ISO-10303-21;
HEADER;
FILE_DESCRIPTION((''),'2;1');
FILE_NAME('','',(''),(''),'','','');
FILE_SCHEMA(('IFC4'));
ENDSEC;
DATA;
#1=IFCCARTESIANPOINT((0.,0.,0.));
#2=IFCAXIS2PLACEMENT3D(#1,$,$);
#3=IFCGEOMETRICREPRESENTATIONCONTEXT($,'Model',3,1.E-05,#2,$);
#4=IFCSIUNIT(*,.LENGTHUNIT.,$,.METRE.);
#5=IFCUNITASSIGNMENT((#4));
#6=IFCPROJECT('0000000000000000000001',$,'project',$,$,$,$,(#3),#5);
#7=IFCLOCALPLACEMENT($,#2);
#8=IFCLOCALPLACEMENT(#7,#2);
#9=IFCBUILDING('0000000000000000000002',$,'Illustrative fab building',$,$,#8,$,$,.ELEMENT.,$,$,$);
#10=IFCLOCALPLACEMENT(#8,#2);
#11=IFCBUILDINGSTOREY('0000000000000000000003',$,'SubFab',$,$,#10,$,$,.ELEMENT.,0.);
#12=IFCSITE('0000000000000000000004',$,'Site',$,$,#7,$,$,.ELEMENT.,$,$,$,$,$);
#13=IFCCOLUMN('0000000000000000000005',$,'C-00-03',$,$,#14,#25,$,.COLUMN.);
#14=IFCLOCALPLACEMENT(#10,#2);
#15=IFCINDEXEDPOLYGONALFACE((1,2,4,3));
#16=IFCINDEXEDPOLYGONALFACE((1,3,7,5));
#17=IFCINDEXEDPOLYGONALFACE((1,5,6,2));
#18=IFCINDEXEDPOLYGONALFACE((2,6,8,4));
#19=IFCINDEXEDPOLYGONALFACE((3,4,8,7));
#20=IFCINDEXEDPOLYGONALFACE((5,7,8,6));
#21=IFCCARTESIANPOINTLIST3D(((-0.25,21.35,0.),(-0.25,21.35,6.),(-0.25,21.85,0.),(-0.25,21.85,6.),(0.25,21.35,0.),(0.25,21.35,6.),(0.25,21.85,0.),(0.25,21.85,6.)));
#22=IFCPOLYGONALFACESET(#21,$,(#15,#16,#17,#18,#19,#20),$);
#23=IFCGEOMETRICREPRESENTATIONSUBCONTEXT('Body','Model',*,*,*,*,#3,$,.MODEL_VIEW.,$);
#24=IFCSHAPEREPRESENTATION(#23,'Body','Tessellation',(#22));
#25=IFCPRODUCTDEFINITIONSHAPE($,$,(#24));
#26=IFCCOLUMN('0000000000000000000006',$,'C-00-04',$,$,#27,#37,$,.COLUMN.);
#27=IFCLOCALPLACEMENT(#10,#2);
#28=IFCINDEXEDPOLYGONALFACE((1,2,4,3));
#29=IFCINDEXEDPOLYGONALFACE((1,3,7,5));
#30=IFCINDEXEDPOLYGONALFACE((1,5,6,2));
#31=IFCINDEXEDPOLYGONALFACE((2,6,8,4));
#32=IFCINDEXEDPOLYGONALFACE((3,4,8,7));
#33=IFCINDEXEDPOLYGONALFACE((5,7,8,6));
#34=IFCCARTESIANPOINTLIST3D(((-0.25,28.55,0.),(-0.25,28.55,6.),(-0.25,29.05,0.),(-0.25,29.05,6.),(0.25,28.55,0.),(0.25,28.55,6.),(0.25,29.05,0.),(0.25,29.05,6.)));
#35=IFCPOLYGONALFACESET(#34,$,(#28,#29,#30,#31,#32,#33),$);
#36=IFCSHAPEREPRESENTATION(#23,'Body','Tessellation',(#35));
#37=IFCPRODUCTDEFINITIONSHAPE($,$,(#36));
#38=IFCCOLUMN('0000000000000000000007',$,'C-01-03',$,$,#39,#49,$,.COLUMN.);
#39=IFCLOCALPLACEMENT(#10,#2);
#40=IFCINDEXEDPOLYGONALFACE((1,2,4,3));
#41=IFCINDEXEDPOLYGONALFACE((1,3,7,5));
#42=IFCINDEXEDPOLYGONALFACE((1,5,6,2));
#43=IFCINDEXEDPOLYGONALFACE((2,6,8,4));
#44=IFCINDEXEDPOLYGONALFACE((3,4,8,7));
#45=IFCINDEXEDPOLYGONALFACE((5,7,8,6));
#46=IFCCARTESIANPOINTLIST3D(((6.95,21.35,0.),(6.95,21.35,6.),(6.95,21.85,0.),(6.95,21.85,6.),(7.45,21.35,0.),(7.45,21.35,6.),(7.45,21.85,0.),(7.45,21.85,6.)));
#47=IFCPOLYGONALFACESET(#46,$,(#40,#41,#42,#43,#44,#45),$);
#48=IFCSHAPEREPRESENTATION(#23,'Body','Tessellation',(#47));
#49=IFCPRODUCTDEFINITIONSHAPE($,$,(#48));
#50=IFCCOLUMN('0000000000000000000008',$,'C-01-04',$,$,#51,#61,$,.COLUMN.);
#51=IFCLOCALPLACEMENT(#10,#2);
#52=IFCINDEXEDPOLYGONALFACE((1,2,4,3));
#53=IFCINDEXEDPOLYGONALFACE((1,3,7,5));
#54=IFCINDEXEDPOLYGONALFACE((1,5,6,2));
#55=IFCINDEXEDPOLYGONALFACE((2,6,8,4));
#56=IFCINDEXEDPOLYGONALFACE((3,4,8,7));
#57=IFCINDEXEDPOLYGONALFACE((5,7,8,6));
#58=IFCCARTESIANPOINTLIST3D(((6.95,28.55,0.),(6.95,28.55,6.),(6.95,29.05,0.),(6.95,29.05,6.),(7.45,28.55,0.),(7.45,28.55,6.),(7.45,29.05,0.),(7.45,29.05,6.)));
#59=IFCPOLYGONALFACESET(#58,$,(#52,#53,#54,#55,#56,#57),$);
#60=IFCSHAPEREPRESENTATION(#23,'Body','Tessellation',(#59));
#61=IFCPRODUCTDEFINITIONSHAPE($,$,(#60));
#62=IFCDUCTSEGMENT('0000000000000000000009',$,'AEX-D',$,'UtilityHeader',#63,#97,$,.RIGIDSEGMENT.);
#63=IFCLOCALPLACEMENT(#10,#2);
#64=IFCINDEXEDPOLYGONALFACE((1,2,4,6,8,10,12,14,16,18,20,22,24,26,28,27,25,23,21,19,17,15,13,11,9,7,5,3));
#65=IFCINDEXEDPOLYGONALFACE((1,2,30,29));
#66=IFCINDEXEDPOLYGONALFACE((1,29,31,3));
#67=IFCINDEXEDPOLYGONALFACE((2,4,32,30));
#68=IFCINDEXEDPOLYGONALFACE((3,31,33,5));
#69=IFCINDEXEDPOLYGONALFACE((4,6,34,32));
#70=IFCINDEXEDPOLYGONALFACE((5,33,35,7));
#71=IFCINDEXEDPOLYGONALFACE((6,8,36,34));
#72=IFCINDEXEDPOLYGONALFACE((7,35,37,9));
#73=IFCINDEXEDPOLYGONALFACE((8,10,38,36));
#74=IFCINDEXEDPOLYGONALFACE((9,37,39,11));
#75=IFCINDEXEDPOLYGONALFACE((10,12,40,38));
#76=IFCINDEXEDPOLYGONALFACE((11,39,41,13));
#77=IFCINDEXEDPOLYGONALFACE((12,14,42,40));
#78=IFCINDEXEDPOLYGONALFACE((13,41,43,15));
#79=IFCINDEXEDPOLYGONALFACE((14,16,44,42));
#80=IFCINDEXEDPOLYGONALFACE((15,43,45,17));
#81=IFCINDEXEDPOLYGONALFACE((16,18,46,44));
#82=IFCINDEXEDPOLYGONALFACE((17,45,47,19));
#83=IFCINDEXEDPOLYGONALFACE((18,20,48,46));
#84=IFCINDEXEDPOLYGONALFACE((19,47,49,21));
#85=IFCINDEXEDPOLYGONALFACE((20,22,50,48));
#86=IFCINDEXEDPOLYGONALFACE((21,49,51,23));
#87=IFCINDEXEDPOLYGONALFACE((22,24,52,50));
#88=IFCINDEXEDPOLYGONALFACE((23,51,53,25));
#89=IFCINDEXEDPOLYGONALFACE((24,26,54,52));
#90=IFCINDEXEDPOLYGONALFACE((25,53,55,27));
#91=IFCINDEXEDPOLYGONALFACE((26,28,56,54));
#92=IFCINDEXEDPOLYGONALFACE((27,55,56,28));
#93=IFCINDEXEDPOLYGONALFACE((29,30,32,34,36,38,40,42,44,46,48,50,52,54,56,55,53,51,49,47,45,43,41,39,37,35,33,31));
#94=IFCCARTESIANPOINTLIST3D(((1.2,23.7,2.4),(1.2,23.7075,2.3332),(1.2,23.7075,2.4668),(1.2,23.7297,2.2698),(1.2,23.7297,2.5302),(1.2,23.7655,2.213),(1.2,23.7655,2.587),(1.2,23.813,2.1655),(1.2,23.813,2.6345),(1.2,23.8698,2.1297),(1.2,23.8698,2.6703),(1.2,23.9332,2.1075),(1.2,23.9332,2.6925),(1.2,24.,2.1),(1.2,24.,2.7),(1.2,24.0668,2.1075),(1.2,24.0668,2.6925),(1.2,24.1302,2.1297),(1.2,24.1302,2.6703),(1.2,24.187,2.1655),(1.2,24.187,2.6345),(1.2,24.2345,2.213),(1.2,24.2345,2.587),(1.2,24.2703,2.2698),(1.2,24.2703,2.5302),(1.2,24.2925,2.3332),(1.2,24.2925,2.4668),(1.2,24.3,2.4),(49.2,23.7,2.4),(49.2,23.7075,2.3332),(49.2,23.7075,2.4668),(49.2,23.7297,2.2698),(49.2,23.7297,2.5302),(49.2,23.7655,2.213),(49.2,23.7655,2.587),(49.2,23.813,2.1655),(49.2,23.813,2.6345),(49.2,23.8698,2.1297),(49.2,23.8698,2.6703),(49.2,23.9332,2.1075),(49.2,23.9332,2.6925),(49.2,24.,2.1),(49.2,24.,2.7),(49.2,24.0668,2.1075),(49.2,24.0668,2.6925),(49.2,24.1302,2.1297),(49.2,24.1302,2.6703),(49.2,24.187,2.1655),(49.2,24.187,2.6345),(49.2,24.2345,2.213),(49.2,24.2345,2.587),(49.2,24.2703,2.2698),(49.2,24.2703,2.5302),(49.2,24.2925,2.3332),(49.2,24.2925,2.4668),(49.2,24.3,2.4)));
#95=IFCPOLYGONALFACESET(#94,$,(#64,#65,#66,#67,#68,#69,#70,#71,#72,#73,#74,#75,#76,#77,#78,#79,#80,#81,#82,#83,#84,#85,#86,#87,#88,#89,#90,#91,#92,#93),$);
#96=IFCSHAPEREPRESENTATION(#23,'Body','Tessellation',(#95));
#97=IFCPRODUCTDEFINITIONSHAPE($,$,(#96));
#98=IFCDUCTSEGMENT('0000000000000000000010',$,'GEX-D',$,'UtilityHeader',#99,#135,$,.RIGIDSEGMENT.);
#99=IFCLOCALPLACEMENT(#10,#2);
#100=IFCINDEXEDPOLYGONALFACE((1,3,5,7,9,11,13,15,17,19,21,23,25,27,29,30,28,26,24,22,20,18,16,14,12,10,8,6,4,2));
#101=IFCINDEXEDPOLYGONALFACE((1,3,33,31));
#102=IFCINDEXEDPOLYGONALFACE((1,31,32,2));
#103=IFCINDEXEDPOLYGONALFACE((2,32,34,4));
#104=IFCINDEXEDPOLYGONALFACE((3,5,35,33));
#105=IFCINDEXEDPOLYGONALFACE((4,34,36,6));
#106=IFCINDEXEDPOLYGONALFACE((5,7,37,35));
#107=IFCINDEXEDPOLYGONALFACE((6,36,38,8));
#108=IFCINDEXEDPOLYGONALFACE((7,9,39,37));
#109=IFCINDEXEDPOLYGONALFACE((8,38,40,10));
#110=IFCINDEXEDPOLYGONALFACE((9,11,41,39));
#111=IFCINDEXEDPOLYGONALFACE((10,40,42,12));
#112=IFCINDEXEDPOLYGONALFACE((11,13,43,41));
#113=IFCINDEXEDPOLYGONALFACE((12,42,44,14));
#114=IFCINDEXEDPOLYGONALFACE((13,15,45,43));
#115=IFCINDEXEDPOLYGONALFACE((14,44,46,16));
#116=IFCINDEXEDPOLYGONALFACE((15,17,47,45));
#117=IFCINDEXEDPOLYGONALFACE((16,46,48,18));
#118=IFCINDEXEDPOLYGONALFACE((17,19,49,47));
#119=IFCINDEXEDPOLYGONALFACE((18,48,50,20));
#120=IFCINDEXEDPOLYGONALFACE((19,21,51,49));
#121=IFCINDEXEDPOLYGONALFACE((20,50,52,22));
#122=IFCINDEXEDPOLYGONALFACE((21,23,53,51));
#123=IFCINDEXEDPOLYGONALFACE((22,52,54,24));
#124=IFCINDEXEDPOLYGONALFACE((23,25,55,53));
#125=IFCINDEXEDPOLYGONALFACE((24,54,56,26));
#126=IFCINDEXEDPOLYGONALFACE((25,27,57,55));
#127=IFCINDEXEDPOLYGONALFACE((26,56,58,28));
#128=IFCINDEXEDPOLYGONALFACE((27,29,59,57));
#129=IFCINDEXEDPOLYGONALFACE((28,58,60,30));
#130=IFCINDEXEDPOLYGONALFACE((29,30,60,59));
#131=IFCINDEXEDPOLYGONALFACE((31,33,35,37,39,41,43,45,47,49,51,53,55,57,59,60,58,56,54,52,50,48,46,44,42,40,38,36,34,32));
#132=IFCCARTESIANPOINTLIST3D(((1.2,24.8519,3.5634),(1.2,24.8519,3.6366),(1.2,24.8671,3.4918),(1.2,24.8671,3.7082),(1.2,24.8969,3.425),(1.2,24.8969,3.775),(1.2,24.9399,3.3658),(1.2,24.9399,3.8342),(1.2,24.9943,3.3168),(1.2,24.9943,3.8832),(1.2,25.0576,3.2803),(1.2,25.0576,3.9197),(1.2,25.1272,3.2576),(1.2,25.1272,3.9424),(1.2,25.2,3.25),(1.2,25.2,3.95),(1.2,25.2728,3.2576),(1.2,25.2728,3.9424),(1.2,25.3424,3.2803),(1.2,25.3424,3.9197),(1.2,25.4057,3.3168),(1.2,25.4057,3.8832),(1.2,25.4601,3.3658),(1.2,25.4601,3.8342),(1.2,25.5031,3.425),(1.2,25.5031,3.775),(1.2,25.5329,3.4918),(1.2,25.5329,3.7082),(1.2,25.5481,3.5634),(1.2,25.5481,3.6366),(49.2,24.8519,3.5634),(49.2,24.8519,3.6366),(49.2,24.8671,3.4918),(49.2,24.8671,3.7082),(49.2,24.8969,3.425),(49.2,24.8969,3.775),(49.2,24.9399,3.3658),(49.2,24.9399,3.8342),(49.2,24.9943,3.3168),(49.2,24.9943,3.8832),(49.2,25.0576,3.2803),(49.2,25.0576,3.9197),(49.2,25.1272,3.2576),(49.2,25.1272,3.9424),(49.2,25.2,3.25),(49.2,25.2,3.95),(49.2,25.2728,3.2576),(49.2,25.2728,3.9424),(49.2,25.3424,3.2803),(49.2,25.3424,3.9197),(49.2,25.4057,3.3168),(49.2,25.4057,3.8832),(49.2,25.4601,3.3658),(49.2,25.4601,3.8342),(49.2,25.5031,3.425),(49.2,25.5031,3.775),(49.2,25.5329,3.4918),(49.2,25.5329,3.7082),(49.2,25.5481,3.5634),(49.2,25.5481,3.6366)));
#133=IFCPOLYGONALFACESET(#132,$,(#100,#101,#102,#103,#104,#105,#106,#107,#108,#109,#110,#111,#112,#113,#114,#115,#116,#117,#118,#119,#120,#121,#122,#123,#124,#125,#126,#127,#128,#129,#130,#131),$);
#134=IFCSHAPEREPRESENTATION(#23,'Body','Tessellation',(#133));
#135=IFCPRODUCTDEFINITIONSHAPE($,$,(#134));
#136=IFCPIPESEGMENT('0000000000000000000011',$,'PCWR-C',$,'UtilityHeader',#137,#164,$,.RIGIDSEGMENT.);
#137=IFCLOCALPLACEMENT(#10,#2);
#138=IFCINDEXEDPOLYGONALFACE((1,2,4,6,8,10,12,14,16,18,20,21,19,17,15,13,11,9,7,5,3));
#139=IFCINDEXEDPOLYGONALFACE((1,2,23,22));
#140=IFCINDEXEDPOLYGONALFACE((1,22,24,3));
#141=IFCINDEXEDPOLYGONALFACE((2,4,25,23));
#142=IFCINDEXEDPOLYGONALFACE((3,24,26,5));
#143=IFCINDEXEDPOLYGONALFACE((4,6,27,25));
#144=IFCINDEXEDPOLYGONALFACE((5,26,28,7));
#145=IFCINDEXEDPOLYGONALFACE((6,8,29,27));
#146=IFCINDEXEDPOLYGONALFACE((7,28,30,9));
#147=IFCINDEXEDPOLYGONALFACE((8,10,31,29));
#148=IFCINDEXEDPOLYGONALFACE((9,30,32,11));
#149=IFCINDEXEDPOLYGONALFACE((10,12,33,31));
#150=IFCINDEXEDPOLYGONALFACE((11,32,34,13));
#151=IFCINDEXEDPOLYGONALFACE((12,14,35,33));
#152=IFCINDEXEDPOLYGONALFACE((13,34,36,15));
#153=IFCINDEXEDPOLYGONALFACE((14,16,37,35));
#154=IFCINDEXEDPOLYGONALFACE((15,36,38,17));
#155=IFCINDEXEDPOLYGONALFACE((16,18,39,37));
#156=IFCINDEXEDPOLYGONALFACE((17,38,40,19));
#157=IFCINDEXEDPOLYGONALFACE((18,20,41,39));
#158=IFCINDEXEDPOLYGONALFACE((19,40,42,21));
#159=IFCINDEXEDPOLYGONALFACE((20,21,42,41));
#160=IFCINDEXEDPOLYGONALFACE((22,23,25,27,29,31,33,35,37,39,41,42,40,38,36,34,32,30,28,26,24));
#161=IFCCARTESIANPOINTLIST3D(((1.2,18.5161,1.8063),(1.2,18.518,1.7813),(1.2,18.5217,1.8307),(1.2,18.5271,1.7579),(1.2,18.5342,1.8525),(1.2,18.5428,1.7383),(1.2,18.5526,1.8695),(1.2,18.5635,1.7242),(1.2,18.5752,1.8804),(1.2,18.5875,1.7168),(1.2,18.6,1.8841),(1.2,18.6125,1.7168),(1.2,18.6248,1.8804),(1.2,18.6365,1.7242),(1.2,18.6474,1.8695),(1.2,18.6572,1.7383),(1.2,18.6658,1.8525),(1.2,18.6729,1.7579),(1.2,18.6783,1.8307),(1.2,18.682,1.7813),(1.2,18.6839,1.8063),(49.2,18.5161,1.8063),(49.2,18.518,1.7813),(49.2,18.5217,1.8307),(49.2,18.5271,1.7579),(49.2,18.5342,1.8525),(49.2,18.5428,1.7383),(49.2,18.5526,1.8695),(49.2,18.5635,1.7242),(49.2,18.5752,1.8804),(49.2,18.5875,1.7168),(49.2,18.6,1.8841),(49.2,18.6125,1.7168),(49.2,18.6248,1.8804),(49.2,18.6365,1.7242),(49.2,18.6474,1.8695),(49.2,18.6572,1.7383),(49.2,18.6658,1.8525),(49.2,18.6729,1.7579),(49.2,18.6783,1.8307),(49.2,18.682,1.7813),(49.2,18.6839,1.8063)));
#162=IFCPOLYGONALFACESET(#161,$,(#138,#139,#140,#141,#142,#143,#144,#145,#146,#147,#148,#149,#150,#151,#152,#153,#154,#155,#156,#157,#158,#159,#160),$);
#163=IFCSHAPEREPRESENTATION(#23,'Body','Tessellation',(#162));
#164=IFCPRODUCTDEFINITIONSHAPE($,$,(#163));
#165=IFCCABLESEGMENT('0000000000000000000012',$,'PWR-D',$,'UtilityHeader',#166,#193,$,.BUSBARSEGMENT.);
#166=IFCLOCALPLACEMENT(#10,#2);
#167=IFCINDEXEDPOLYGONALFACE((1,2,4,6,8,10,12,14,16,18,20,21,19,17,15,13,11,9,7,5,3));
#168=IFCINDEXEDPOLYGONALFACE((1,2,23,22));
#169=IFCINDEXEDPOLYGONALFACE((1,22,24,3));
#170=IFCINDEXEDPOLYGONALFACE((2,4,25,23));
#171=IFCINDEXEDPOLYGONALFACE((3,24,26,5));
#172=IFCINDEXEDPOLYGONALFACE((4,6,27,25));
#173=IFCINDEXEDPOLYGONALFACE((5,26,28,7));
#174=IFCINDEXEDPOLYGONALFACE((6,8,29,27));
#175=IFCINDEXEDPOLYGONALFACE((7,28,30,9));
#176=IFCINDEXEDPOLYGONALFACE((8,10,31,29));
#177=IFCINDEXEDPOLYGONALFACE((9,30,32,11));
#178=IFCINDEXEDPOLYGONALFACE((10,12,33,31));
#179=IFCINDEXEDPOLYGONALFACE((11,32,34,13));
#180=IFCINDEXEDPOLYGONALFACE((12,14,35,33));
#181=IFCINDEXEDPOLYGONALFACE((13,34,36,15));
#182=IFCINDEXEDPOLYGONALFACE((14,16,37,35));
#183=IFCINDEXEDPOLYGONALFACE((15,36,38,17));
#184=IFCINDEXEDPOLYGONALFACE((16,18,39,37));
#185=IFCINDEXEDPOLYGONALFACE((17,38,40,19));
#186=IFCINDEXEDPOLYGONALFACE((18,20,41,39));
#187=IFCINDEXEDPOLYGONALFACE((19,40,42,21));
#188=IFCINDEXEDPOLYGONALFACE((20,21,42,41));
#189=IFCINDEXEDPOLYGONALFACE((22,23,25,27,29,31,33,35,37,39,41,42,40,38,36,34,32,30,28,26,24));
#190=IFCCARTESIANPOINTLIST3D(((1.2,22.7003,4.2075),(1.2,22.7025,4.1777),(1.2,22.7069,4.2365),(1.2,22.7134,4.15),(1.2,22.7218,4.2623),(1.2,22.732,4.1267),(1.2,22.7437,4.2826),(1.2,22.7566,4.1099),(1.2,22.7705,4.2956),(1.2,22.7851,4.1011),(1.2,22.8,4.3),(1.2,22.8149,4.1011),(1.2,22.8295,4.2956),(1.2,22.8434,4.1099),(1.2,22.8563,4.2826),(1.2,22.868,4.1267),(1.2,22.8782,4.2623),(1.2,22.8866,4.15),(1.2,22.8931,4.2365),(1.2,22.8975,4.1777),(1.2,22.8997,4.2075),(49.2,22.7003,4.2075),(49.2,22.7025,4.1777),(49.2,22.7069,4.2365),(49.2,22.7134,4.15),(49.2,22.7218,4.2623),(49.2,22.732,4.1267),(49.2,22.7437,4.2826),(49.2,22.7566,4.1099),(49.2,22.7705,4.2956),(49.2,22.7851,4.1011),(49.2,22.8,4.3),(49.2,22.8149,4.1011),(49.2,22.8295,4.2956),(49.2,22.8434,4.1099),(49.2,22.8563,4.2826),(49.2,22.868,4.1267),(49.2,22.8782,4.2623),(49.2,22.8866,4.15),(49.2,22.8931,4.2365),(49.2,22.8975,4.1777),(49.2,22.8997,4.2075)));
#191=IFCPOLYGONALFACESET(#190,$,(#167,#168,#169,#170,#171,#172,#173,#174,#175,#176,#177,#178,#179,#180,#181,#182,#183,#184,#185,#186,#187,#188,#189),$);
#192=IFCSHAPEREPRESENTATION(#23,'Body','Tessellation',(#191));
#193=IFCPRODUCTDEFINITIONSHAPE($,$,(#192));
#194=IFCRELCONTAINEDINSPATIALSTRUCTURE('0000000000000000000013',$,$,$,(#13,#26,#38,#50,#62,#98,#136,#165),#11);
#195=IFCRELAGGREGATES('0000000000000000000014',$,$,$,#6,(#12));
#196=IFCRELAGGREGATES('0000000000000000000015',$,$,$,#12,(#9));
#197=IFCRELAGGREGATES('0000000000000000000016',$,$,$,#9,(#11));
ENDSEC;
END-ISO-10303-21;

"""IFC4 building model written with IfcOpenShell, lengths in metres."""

from ifc_helpers import new_model, entity, si_unit, frame, origin, origin_2d, place, context, subcontext, project, spatial, rectangle, extrude, element, save


model = new_model("IFC4")

# Units and contexts
model_context = context("Model", 3, precision=1e-05, world=origin())
body_context = subcontext(model_context, "Body", "Model", "MODEL_VIEW")
ifc_project = project(units=[si_unit("LENGTHUNIT", "METRE")], contexts=[model_context])

# Site, building, storey
site_placement = place(None, origin())
site = spatial("IfcSite", under=ifc_project, at=site_placement, Name="Site", CompositionType="ELEMENT")
building_placement = place(site_placement, origin())
building = spatial("IfcBuilding", under=site, at=building_placement, Name="Illustrative fab building", CompositionType="ELEMENT")
storey_placement = place(building_placement, origin())
storey = spatial("IfcBuildingStorey", under=building, at=storey_placement, Name="SubFab", CompositionType="ELEMENT", Elevation=0.0)

# Columns
for number, where, name in (
    (1, (0.0, 21.6, 0.0), "C-00-03"),
    (2, (0.0, 28.8, 0.0), "C-00-04"),
    (3, (7.2, 21.6, 0.0), "C-01-03"),
    (4, (7.2, 28.8, 0.0), "C-01-04"),
):
    element("IfcColumn", number, at=place(storey_placement, frame(where)), inside=storey, Name=name, PredefinedType="COLUMN", context=body_context, shape_type="SweptSolid", body=[
        extrude(rectangle(XDim=0.5, YDim=0.5, at=origin_2d()), origin(), (0.0, 0.0, 1.0), 6.0),
    ])

# Duct segments
duct_segment_1_placement = place(storey_placement, frame((1.2, 24.0, 2.4)))
element("IfcDuctSegment", 5, at=duct_segment_1_placement, inside=storey, Name="AEX-D", ObjectType="UtilityHeader", PredefinedType="RIGIDSEGMENT", context=body_context, shape_type="AdvancedSweptSolid", body=[
    entity("IfcSweptDiskSolid", entity("IfcPolyline", [entity("IfcCartesianPoint", [0.0, 0.0, 0.0]), entity("IfcCartesianPoint", [48.0, 0.0, 0.0])]), 0.3),
])
duct_segment_2_placement = place(storey_placement, frame((1.2, 25.2, 3.6)))
element("IfcDuctSegment", 6, at=duct_segment_2_placement, inside=storey, Name="GEX-D", ObjectType="UtilityHeader", PredefinedType="RIGIDSEGMENT", context=body_context, shape_type="AdvancedSweptSolid", body=[
    entity("IfcSweptDiskSolid", entity("IfcPolyline", [entity("IfcCartesianPoint", [0.0, 0.0, 0.0]), entity("IfcCartesianPoint", [48.0, 0.0, 0.0])]), 0.35),
])

# Pipe segment
pipe_segment_placement = place(storey_placement, frame((1.2, 18.6, 1.8)))
element("IfcPipeSegment", 7, at=pipe_segment_placement, inside=storey, Name="PCWR-C", ObjectType="UtilityHeader", PredefinedType="RIGIDSEGMENT", context=body_context, shape_type="AdvancedSweptSolid", body=[
    entity("IfcSweptDiskSolid", entity("IfcPolyline", [entity("IfcCartesianPoint", [0.0, 0.0, 0.0]), entity("IfcCartesianPoint", [48.0, 0.0, 0.0])]), 0.0841),
])

# Cable segment
cable_segment_placement = place(storey_placement, frame((1.2, 22.8, 4.2)))
element("IfcCableSegment", 8, at=cable_segment_placement, inside=storey, Name="PWR-D", ObjectType="UtilityHeader", PredefinedType="BUSBARSEGMENT", context=body_context, shape_type="AdvancedSweptSolid", body=[
    entity("IfcSweptDiskSolid", entity("IfcPolyline", [entity("IfcCartesianPoint", [0.0, 0.0, 0.0]), entity("IfcCartesianPoint", [48.0, 0.0, 0.0])]), 0.1),
])

save(model, "model.ifc")
